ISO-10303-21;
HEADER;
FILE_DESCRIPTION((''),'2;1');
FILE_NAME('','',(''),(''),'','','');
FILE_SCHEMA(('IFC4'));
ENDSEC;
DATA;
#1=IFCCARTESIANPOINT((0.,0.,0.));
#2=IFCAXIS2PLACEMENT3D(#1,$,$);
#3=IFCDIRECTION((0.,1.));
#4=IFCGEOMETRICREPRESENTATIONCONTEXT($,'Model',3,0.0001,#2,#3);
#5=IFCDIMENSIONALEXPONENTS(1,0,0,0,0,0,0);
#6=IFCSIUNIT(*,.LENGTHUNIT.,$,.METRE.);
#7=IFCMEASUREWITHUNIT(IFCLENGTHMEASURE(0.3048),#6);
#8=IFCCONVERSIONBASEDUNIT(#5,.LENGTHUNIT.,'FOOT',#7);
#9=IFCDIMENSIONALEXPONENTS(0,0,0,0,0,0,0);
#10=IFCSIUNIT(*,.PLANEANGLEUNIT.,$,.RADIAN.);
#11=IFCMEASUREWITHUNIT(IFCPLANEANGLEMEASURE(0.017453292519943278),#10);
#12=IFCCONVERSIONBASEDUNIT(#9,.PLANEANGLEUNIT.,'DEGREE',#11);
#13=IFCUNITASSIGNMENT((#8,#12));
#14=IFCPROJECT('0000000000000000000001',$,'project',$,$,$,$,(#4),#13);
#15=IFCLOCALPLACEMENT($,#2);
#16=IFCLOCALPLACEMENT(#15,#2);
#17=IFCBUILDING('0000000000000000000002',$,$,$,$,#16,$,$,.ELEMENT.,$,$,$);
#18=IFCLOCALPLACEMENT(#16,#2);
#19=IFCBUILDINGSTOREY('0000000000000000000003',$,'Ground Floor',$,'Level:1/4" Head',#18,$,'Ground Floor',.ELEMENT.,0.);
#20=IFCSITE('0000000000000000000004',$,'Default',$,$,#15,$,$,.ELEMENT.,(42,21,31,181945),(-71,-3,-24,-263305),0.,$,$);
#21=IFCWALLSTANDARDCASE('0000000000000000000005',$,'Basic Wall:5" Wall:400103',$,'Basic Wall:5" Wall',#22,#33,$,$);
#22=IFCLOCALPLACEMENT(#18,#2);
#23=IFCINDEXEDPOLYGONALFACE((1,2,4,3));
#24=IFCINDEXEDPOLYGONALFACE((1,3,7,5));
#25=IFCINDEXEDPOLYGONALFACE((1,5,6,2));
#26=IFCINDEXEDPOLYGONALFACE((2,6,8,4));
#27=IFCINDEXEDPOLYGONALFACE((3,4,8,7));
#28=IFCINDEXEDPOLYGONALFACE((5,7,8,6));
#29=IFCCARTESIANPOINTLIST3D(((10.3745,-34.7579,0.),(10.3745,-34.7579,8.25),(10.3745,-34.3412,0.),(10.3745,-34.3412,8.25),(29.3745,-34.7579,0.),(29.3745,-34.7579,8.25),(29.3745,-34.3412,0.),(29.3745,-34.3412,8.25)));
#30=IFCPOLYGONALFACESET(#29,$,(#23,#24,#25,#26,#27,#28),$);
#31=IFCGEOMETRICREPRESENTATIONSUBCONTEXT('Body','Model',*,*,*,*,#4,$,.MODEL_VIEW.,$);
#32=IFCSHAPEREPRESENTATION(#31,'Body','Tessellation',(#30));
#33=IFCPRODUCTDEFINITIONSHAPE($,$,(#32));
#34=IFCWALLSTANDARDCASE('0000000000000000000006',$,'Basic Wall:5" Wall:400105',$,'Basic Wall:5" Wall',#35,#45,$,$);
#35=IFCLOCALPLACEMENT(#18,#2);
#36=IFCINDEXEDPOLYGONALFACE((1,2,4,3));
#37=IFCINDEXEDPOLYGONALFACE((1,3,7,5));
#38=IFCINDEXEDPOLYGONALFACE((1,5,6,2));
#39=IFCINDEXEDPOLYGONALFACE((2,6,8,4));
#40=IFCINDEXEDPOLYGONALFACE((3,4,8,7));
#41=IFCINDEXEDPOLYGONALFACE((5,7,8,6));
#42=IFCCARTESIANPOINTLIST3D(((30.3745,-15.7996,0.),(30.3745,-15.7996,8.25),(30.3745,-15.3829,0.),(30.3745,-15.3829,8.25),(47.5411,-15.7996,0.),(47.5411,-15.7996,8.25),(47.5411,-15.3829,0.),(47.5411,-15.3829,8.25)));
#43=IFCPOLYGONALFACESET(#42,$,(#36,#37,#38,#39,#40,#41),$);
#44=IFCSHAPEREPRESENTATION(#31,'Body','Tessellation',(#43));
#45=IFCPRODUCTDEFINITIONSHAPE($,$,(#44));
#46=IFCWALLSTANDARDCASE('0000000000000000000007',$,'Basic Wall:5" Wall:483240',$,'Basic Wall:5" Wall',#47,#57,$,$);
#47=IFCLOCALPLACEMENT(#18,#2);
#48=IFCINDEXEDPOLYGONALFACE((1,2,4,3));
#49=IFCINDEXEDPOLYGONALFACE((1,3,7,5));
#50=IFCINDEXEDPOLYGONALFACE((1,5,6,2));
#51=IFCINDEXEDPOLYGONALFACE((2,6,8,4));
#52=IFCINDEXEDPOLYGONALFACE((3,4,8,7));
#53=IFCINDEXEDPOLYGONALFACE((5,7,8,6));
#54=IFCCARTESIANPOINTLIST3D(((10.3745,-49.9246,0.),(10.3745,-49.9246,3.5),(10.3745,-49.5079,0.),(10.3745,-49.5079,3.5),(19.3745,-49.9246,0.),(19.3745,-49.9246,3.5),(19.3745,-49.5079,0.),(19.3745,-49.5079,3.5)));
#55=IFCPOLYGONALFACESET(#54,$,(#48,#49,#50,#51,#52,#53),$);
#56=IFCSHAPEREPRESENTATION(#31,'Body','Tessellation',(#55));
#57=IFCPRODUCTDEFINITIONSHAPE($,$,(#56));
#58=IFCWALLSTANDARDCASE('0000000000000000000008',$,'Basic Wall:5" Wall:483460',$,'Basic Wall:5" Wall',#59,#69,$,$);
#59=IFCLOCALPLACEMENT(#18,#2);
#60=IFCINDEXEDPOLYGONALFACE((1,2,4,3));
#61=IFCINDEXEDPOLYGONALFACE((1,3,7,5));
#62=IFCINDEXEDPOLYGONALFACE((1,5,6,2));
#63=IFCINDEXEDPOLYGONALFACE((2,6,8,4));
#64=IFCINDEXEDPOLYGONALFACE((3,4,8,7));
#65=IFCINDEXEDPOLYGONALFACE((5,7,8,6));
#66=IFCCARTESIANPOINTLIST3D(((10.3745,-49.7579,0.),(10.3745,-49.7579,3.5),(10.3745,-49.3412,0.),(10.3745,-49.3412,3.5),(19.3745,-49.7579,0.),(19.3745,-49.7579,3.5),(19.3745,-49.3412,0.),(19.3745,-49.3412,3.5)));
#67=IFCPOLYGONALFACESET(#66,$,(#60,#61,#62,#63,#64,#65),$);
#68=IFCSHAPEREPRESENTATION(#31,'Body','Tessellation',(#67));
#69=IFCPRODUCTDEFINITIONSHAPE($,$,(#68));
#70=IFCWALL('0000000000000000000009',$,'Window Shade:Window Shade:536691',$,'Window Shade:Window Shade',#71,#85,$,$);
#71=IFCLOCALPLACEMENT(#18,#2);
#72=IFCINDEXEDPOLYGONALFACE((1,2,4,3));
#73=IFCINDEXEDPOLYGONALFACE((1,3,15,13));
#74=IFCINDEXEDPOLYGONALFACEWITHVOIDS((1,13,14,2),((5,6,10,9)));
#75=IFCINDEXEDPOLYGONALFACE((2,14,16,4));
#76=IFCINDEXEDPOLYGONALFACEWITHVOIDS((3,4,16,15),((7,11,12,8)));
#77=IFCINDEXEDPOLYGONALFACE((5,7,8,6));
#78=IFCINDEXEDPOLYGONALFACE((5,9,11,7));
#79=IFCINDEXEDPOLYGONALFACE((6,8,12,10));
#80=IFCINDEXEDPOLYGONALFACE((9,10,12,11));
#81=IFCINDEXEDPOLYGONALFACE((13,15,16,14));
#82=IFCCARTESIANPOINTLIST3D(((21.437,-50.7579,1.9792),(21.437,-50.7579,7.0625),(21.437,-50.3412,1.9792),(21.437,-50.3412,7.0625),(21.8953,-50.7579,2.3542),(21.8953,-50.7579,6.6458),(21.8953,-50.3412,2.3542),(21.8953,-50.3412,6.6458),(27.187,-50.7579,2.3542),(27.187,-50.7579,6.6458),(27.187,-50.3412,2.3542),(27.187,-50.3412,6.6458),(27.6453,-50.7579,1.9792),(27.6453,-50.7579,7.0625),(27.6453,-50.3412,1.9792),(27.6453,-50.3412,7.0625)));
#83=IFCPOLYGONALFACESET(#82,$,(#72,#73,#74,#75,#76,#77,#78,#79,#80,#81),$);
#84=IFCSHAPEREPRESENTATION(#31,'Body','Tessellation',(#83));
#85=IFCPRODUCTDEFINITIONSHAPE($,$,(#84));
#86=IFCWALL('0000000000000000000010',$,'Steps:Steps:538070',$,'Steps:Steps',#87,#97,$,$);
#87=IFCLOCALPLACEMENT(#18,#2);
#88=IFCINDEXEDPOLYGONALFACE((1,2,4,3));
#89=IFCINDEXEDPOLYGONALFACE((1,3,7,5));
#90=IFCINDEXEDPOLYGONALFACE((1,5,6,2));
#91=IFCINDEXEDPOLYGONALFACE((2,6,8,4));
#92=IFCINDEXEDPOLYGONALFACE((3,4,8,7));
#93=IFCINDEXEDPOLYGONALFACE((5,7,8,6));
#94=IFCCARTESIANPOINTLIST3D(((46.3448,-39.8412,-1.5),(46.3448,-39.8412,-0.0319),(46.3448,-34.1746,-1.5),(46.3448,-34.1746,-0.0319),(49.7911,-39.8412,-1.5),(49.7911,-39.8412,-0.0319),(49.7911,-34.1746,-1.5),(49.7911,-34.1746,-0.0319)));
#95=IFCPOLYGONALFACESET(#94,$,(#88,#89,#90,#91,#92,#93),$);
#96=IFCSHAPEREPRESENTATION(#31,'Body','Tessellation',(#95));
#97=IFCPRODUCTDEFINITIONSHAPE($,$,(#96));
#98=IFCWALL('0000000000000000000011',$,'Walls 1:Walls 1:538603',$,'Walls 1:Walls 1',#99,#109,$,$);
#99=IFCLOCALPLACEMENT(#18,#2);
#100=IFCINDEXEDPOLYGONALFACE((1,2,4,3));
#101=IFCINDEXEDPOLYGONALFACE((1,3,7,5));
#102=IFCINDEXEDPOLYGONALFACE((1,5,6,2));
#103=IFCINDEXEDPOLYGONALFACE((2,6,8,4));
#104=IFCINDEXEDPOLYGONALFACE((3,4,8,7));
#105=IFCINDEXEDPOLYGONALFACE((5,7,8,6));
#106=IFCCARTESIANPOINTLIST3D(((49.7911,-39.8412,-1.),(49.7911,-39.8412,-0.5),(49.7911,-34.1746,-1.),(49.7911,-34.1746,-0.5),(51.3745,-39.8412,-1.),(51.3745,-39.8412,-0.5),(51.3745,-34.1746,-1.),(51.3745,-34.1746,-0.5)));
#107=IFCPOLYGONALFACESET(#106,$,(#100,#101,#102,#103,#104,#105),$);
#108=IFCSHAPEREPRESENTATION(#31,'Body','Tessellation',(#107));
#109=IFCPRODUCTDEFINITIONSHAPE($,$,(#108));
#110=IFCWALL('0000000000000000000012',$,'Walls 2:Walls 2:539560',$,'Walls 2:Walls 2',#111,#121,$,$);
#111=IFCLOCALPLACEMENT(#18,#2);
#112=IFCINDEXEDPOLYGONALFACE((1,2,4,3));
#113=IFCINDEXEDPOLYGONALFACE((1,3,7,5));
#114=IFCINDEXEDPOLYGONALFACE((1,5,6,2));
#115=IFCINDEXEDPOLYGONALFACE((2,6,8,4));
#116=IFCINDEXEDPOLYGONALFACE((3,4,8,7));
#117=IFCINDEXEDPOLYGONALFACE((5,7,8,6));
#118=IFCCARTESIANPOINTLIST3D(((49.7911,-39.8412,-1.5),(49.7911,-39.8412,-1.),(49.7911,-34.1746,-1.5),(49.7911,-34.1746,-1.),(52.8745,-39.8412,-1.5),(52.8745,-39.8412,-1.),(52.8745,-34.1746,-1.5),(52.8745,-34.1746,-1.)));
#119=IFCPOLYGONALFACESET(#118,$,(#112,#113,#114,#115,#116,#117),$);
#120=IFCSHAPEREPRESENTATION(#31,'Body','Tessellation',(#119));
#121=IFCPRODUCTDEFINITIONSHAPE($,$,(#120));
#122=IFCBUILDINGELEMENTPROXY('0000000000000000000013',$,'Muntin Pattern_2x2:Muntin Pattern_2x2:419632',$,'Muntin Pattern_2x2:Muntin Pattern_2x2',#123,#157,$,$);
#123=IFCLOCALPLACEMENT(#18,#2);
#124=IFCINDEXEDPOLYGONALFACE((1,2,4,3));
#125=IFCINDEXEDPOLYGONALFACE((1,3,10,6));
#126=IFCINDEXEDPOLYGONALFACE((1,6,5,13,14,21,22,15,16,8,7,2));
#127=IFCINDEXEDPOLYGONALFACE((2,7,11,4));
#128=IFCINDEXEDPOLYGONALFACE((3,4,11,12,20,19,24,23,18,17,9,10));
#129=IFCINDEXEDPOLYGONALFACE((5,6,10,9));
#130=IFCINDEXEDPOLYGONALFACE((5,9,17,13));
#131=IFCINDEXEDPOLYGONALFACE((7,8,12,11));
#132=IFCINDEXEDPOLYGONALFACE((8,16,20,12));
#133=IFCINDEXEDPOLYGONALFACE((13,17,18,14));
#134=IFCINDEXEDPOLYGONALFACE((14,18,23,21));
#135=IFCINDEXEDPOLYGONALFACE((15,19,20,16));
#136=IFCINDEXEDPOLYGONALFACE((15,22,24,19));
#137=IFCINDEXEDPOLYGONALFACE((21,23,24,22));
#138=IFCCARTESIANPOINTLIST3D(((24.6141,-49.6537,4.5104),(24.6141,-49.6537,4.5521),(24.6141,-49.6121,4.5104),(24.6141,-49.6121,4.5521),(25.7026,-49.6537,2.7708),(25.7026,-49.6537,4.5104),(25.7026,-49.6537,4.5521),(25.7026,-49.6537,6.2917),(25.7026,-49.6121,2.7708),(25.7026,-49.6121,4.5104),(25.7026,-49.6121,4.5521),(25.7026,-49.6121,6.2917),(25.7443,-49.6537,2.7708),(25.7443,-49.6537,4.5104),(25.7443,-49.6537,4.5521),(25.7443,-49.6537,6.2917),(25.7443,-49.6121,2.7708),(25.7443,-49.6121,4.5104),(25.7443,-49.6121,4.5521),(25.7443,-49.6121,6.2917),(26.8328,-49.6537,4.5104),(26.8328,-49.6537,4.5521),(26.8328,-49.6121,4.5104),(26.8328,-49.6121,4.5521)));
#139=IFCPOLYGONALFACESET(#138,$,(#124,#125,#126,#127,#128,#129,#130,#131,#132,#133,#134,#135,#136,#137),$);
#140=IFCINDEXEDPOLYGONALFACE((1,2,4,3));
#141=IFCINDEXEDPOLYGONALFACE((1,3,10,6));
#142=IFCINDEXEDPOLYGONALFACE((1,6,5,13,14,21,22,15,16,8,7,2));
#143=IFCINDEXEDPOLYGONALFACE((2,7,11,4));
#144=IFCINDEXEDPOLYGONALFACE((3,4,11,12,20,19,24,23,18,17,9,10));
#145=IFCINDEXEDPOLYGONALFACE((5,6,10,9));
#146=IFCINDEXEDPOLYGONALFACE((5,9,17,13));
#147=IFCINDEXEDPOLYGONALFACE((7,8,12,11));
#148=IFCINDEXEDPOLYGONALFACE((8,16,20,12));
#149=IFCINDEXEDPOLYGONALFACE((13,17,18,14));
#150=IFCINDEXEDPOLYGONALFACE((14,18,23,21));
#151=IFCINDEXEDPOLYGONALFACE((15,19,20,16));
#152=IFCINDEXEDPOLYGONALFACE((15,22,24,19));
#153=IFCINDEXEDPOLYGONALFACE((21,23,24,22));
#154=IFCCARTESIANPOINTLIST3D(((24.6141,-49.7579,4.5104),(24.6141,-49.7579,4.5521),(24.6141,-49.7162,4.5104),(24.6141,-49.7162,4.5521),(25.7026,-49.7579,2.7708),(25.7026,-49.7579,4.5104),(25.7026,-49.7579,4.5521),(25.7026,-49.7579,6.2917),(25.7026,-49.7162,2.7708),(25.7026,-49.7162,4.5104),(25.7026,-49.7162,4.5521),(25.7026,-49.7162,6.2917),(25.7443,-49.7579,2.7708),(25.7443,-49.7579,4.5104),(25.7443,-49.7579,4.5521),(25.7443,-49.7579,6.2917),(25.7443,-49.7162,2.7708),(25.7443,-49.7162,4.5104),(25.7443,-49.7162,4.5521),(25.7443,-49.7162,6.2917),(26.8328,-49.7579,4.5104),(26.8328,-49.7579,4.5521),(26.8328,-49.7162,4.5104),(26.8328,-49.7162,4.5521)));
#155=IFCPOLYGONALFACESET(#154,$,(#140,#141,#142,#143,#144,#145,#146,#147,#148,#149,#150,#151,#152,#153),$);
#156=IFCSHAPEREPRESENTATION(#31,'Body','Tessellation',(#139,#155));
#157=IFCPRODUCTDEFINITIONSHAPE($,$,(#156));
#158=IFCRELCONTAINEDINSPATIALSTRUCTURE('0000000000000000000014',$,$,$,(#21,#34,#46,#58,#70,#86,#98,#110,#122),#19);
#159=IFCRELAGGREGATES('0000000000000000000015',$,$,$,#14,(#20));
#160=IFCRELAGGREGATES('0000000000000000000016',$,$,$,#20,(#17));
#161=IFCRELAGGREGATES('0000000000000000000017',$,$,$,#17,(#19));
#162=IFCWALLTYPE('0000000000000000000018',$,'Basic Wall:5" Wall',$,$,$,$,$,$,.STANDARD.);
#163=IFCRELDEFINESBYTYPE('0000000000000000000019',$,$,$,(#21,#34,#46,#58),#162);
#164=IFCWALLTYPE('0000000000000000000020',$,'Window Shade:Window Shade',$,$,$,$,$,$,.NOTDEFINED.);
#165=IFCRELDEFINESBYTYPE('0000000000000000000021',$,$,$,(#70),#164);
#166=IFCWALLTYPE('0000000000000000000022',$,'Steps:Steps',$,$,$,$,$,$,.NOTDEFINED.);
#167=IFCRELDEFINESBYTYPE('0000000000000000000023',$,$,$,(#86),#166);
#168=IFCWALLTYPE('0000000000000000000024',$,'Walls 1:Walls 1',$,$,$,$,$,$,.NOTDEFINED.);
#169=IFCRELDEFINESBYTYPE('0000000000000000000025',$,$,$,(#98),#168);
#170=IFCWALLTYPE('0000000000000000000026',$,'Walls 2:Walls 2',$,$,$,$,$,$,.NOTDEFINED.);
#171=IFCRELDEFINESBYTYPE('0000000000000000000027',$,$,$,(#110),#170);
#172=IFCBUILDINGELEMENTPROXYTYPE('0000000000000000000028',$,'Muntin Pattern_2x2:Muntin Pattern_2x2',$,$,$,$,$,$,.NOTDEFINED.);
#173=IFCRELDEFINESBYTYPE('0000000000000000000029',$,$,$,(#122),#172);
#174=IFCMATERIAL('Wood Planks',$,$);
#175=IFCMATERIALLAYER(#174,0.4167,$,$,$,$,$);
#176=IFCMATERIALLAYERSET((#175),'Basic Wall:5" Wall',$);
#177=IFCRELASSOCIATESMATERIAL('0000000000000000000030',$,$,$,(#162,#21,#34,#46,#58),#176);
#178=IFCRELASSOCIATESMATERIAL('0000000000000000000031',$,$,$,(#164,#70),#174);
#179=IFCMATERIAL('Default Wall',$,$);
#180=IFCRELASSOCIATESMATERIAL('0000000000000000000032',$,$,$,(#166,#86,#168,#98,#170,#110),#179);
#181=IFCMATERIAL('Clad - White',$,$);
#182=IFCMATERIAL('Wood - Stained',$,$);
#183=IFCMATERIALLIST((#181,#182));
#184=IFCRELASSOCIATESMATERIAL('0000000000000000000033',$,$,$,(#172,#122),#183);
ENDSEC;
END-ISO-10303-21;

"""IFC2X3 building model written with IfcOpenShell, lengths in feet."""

from ifc_helpers import new_model, entity, si_unit, converted_unit, direction, frame, frame_2d, origin, place, context, subcontext, project, spatial, polyline, rectangle, outline, extrude, source, transform, mapped, material, material_list, layer, layer_set, layer_usage, type_object, type_shapes, element, save


model = new_model("IFC2X3")

# Units and contexts
model_context = context("Model", 3, precision=0.0001, world=origin(), true_north=direction((0.0, 1.0)))
body_context = subcontext(model_context, "Body", "Model", "MODEL_VIEW")
ifc_project = project(units=[converted_unit("LENGTHUNIT", "FOOT", entity("IfcLengthMeasure", 0.3048), si_unit("LENGTHUNIT", "METRE"), dimensions=[1, 0, 0, 0, 0, 0, 0]), converted_unit("PLANEANGLEUNIT", "DEGREE", entity("IfcPlaneAngleMeasure", 0.017453292519943278), si_unit("PLANEANGLEUNIT", "RADIAN"), dimensions=[0, 0, 0, 0, 0, 0, 0])], contexts=[model_context])

# Site, building, storey
site_placement = place(None, origin())
site = spatial("IfcSite", under=ifc_project, at=site_placement, Name="Default", CompositionType="ELEMENT", RefLatitude=(42, 21, 31, 181945), RefLongitude=(-71, -3, -24, -263305), RefElevation=0.0)
building_placement = place(site_placement, origin())
building = spatial("IfcBuilding", under=site, at=building_placement, CompositionType="ELEMENT")
storey_placement = place(building_placement, origin())
storey = spatial("IfcBuildingStorey", under=building, at=storey_placement, Name="Ground Floor", ObjectType="Level:1/4\" Head", LongName="Ground Floor", CompositionType="ELEMENT", Elevation=0.0)

# Shared definitions
ifc_material_1 = material(Name="Default Wall")

# Shared definitions
ifc_material_2 = material(Name="Wood Planks")
ifc_layer_1 = layer(ifc_material_2, 0.4167)
ifc_layer_set_1 = layer_set([ifc_layer_1], Name="Basic Wall:5\" Wall")
ifc_layer_usage_1 = layer_usage(ifc_layer_set_1, "AXIS2", "NEGATIVE", 0.2083)
wall_type_1 = type_object("IfcWallType", Name="Basic Wall:5\" Wall", PredefinedType="STANDARD", material=ifc_layer_set_1)

# Wall
wall_1_placement = place(storey_placement, frame((29.3745, -34.5496, 0.0), z_axis=(0.0, 0.0, 1.0), x_axis=(-1.0, 0.0, 0.0)))
element("IfcWallStandardCase", 1, at=wall_1_placement, inside=storey, type_object=wall_type_1, material=ifc_layer_usage_1, Name="Basic Wall:5\" Wall:400103", ObjectType="Basic Wall:5\" Wall", context=body_context, shape_type="SweptSolid", body=[
    extrude(rectangle(XDim=19.0, YDim=0.4167, at=frame_2d((9.5, 0.0), x_axis=(-1.0, 0.0))), origin(), (0.0, 0.0, 1.0), 8.25),
])

# Walls
wall_2_placement = place(storey_placement, frame((30.3745, -15.5912, 0.0)))
element("IfcWallStandardCase", 2, at=wall_2_placement, inside=storey, type_object=wall_type_1, material=ifc_layer_usage_1, Name="Basic Wall:5\" Wall:400105", ObjectType="Basic Wall:5\" Wall", context=body_context, shape_type="SweptSolid", body=[
    extrude(rectangle(XDim=17.1667, YDim=0.4167, at=frame_2d((8.5833, 0.0), x_axis=(-1.0, 0.0))), origin(), (0.0, 0.0, 1.0), 8.25),
])
wall_3_placement = place(storey_placement, frame((10.3745, -49.7162, 0.0)))
element("IfcWallStandardCase", 3, at=wall_3_placement, inside=storey, type_object=wall_type_1, material=ifc_layer_usage_1, Name="Basic Wall:5\" Wall:483240", ObjectType="Basic Wall:5\" Wall", context=body_context, shape_type="SweptSolid", body=[
    extrude(rectangle(XDim=9.0, YDim=0.4167, at=frame_2d((4.5, 0.0), x_axis=(-1.0, 0.0))), origin(), (0.0, 0.0, 1.0), 3.5),
])
wall_4_placement = place(storey_placement, frame((10.3745, -49.5496, 0.0)))
element("IfcWallStandardCase", 4, at=wall_4_placement, inside=storey, type_object=wall_type_1, material=ifc_layer_usage_1, Name="Basic Wall:5\" Wall:483460", ObjectType="Basic Wall:5\" Wall", context=body_context, shape_type="SweptSolid", body=[
    extrude(rectangle(XDim=9.0, YDim=0.4167, at=frame_2d((4.5, 0.0), x_axis=(-1.0, 0.0))), origin(), (0.0, 0.0, 1.0), 3.5),
])

# Wall, opening
wall_type_2 = type_object("IfcWallType", Name="Window Shade:Window Shade", PredefinedType="NOTDEFINED", material=ifc_material_2)
wall_5_placement = place(storey_placement, frame((21.437, -50.7579, 1.9792)))
wall_5 = element("IfcWall", 5, at=wall_5_placement, inside=storey, type_object=wall_type_2, material=ifc_material_2, Name="Window Shade:Window Shade:536691", ObjectType="Window Shade:Window Shade", context=body_context, shape_type="SweptSolid", body=[
    extrude(rectangle(XDim=0.4167, YDim=6.2083, at=frame_2d((0.0, 0.0), x_axis=(1.0, 0.0))), frame((3.1042, 0.2083, 0.0), z_axis=(0.0, 0.0, 1.0), x_axis=(0.0, 1.0, 0.0)), (0.0, 0.0, 1.0), 5.0833),
])
opening_1_placement = place(storey_placement, frame((21.437, -50.7579, 1.9792)))
element("IfcOpeningElement", 6, at=opening_1_placement, cuts=wall_5, ObjectType="Opening", context=body_context, shape_type="SweptSolid", body=[
    extrude(rectangle(XDim=4.2917, YDim=5.2917, at=frame_2d((0.0, 0.0), x_axis=(0.0, 1.0))), frame((3.1042, 0.4167, 2.5208), z_axis=(0.0, -1.0, 0.0), x_axis=(-1.0, 0.0, 0.0)), (0.0, 0.0, 1.0), 0.4167),
])

# Walls
wall_type_3 = type_object("IfcWallType", Name="Steps:Steps", PredefinedType="NOTDEFINED", material=ifc_material_1)
wall_6_placement = place(storey_placement, frame((46.3448, -39.8412, -1.5), z_axis=(0.0, 0.0, 1.0), x_axis=(0.0, 1.0, 0.0)))
element("IfcWall", 7, at=wall_6_placement, inside=storey, type_object=wall_type_3, material=ifc_material_1, Name="Steps:Steps:538070", ObjectType="Steps:Steps", context=body_context, shape_type="SweptSolid", body=[
    extrude(rectangle(XDim=5.6667, YDim=3.4464, at=frame_2d((0.0, 0.0), x_axis=(1.0, 0.0))), frame((2.8333, -1.7232, 0.0), z_axis=(0.0, 0.0, 1.0), x_axis=(-1.0, 0.0, 0.0)), (0.0, 0.0, 1.0), 1.4681),
])
wall_type_4 = type_object("IfcWallType", Name="Walls 1:Walls 1", PredefinedType="NOTDEFINED", material=ifc_material_1)
wall_7_placement = place(storey_placement, frame((49.7911, -39.8412, -1.0), z_axis=(0.0, 0.0, 1.0), x_axis=(0.0, 1.0, 0.0)))
element("IfcWall", 8, at=wall_7_placement, inside=storey, type_object=wall_type_4, material=ifc_material_1, Name="Walls 1:Walls 1:538603", ObjectType="Walls 1:Walls 1", context=body_context, shape_type="SweptSolid", body=[
    extrude(rectangle(XDim=1.5833, YDim=5.6667, at=frame_2d((0.0, 0.0), x_axis=(1.0, 0.0))), frame((2.8333, -0.7917, 0.0), z_axis=(0.0, 0.0, 1.0), x_axis=(0.0, 1.0, 0.0)), (0.0, 0.0, 1.0), 0.5),
])
wall_type_5 = type_object("IfcWallType", Name="Walls 2:Walls 2", PredefinedType="NOTDEFINED", material=ifc_material_1)
wall_8_placement = place(storey_placement, frame((49.7911, -39.8412, -1.5), z_axis=(0.0, 0.0, 1.0), x_axis=(0.0, 1.0, 0.0)))
element("IfcWall", 9, at=wall_8_placement, inside=storey, type_object=wall_type_5, material=ifc_material_1, Name="Walls 2:Walls 2:539560", ObjectType="Walls 2:Walls 2", context=body_context, shape_type="SweptSolid", body=[
    extrude(rectangle(XDim=3.0833, YDim=5.6667, at=frame_2d((0.0, 0.0), x_axis=(1.0, 0.0))), frame((2.8333, -1.5417, 0.0), z_axis=(0.0, 0.0, 1.0), x_axis=(0.0, 1.0, 0.0)), (0.0, 0.0, 1.0), 0.5),
])

# Building element proxy
ifc_material_3 = material(Name="Clad - White")
ifc_material_4 = material(Name="Wood - Stained")
ifc_material_list_1 = material_list([ifc_material_3, ifc_material_4])
building_element_proxy_type_1 = type_object("IfcBuildingElementProxyType", Name="Muntin Pattern_2x2:Muntin Pattern_2x2", PredefinedType="NOTDEFINED", material=ifc_material_list_1)
shared_shape_1 = source(origin(), body_context, "Body", "SweptSolid", [
    extrude(outline(polyline([(0.0208, -0.0208), (1.7604, -0.0208), (1.7604, 0.0208), (0.0208, 0.0208), (0.0208, 1.1094), (-0.0208, 1.1094), (-0.0208, 0.0208), (-1.7604, 0.0208), (-1.7604, -0.0208), (-0.0208, -0.0208), (-0.0208, -1.1094), (0.0208, -1.1094), (0.0208, -0.0208)])), frame((0.0, 0.0313, 1.7604), z_axis=(0.0, 1.0, 0.0), x_axis=(0.0, 0.0, 1.0)), (0.0, 0.0, 1.0), 0.0417),
    extrude(outline(polyline([(0.0208, -0.0208), (1.7604, -0.0208), (1.7604, 0.0208), (0.0208, 0.0208), (0.0208, 1.1094), (-0.0208, 1.1094), (-0.0208, 0.0208), (-1.7604, 0.0208), (-1.7604, -0.0208), (-0.0208, -0.0208), (-0.0208, -1.1094), (0.0208, -1.1094), (0.0208, -0.0208)])), frame((0.0, -0.0729, 1.7604), z_axis=(0.0, 1.0, 0.0), x_axis=(0.0, 0.0, 1.0)), (0.0, 0.0, 1.0), 0.0417),
])
type_shapes(building_element_proxy_type_1, [shared_shape_1])
for number, where, name in (
    (10, (25.7234, -49.685, 2.7708), "Muntin Pattern_2x2:Muntin Pattern_2x2:419632"),
):
    element("IfcBuildingElementProxy", number, at=place(storey_placement, frame(where)), inside=storey, type_object=building_element_proxy_type_1, material=ifc_material_list_1, Name=name, ObjectType="Muntin Pattern_2x2:Muntin Pattern_2x2", context=body_context, shape_type="MappedRepresentation", body=[
        mapped(shared_shape_1, transform((0.0, 0.0, 0.0), scale=1.0)),
    ])

save(model, "model.ifc")
